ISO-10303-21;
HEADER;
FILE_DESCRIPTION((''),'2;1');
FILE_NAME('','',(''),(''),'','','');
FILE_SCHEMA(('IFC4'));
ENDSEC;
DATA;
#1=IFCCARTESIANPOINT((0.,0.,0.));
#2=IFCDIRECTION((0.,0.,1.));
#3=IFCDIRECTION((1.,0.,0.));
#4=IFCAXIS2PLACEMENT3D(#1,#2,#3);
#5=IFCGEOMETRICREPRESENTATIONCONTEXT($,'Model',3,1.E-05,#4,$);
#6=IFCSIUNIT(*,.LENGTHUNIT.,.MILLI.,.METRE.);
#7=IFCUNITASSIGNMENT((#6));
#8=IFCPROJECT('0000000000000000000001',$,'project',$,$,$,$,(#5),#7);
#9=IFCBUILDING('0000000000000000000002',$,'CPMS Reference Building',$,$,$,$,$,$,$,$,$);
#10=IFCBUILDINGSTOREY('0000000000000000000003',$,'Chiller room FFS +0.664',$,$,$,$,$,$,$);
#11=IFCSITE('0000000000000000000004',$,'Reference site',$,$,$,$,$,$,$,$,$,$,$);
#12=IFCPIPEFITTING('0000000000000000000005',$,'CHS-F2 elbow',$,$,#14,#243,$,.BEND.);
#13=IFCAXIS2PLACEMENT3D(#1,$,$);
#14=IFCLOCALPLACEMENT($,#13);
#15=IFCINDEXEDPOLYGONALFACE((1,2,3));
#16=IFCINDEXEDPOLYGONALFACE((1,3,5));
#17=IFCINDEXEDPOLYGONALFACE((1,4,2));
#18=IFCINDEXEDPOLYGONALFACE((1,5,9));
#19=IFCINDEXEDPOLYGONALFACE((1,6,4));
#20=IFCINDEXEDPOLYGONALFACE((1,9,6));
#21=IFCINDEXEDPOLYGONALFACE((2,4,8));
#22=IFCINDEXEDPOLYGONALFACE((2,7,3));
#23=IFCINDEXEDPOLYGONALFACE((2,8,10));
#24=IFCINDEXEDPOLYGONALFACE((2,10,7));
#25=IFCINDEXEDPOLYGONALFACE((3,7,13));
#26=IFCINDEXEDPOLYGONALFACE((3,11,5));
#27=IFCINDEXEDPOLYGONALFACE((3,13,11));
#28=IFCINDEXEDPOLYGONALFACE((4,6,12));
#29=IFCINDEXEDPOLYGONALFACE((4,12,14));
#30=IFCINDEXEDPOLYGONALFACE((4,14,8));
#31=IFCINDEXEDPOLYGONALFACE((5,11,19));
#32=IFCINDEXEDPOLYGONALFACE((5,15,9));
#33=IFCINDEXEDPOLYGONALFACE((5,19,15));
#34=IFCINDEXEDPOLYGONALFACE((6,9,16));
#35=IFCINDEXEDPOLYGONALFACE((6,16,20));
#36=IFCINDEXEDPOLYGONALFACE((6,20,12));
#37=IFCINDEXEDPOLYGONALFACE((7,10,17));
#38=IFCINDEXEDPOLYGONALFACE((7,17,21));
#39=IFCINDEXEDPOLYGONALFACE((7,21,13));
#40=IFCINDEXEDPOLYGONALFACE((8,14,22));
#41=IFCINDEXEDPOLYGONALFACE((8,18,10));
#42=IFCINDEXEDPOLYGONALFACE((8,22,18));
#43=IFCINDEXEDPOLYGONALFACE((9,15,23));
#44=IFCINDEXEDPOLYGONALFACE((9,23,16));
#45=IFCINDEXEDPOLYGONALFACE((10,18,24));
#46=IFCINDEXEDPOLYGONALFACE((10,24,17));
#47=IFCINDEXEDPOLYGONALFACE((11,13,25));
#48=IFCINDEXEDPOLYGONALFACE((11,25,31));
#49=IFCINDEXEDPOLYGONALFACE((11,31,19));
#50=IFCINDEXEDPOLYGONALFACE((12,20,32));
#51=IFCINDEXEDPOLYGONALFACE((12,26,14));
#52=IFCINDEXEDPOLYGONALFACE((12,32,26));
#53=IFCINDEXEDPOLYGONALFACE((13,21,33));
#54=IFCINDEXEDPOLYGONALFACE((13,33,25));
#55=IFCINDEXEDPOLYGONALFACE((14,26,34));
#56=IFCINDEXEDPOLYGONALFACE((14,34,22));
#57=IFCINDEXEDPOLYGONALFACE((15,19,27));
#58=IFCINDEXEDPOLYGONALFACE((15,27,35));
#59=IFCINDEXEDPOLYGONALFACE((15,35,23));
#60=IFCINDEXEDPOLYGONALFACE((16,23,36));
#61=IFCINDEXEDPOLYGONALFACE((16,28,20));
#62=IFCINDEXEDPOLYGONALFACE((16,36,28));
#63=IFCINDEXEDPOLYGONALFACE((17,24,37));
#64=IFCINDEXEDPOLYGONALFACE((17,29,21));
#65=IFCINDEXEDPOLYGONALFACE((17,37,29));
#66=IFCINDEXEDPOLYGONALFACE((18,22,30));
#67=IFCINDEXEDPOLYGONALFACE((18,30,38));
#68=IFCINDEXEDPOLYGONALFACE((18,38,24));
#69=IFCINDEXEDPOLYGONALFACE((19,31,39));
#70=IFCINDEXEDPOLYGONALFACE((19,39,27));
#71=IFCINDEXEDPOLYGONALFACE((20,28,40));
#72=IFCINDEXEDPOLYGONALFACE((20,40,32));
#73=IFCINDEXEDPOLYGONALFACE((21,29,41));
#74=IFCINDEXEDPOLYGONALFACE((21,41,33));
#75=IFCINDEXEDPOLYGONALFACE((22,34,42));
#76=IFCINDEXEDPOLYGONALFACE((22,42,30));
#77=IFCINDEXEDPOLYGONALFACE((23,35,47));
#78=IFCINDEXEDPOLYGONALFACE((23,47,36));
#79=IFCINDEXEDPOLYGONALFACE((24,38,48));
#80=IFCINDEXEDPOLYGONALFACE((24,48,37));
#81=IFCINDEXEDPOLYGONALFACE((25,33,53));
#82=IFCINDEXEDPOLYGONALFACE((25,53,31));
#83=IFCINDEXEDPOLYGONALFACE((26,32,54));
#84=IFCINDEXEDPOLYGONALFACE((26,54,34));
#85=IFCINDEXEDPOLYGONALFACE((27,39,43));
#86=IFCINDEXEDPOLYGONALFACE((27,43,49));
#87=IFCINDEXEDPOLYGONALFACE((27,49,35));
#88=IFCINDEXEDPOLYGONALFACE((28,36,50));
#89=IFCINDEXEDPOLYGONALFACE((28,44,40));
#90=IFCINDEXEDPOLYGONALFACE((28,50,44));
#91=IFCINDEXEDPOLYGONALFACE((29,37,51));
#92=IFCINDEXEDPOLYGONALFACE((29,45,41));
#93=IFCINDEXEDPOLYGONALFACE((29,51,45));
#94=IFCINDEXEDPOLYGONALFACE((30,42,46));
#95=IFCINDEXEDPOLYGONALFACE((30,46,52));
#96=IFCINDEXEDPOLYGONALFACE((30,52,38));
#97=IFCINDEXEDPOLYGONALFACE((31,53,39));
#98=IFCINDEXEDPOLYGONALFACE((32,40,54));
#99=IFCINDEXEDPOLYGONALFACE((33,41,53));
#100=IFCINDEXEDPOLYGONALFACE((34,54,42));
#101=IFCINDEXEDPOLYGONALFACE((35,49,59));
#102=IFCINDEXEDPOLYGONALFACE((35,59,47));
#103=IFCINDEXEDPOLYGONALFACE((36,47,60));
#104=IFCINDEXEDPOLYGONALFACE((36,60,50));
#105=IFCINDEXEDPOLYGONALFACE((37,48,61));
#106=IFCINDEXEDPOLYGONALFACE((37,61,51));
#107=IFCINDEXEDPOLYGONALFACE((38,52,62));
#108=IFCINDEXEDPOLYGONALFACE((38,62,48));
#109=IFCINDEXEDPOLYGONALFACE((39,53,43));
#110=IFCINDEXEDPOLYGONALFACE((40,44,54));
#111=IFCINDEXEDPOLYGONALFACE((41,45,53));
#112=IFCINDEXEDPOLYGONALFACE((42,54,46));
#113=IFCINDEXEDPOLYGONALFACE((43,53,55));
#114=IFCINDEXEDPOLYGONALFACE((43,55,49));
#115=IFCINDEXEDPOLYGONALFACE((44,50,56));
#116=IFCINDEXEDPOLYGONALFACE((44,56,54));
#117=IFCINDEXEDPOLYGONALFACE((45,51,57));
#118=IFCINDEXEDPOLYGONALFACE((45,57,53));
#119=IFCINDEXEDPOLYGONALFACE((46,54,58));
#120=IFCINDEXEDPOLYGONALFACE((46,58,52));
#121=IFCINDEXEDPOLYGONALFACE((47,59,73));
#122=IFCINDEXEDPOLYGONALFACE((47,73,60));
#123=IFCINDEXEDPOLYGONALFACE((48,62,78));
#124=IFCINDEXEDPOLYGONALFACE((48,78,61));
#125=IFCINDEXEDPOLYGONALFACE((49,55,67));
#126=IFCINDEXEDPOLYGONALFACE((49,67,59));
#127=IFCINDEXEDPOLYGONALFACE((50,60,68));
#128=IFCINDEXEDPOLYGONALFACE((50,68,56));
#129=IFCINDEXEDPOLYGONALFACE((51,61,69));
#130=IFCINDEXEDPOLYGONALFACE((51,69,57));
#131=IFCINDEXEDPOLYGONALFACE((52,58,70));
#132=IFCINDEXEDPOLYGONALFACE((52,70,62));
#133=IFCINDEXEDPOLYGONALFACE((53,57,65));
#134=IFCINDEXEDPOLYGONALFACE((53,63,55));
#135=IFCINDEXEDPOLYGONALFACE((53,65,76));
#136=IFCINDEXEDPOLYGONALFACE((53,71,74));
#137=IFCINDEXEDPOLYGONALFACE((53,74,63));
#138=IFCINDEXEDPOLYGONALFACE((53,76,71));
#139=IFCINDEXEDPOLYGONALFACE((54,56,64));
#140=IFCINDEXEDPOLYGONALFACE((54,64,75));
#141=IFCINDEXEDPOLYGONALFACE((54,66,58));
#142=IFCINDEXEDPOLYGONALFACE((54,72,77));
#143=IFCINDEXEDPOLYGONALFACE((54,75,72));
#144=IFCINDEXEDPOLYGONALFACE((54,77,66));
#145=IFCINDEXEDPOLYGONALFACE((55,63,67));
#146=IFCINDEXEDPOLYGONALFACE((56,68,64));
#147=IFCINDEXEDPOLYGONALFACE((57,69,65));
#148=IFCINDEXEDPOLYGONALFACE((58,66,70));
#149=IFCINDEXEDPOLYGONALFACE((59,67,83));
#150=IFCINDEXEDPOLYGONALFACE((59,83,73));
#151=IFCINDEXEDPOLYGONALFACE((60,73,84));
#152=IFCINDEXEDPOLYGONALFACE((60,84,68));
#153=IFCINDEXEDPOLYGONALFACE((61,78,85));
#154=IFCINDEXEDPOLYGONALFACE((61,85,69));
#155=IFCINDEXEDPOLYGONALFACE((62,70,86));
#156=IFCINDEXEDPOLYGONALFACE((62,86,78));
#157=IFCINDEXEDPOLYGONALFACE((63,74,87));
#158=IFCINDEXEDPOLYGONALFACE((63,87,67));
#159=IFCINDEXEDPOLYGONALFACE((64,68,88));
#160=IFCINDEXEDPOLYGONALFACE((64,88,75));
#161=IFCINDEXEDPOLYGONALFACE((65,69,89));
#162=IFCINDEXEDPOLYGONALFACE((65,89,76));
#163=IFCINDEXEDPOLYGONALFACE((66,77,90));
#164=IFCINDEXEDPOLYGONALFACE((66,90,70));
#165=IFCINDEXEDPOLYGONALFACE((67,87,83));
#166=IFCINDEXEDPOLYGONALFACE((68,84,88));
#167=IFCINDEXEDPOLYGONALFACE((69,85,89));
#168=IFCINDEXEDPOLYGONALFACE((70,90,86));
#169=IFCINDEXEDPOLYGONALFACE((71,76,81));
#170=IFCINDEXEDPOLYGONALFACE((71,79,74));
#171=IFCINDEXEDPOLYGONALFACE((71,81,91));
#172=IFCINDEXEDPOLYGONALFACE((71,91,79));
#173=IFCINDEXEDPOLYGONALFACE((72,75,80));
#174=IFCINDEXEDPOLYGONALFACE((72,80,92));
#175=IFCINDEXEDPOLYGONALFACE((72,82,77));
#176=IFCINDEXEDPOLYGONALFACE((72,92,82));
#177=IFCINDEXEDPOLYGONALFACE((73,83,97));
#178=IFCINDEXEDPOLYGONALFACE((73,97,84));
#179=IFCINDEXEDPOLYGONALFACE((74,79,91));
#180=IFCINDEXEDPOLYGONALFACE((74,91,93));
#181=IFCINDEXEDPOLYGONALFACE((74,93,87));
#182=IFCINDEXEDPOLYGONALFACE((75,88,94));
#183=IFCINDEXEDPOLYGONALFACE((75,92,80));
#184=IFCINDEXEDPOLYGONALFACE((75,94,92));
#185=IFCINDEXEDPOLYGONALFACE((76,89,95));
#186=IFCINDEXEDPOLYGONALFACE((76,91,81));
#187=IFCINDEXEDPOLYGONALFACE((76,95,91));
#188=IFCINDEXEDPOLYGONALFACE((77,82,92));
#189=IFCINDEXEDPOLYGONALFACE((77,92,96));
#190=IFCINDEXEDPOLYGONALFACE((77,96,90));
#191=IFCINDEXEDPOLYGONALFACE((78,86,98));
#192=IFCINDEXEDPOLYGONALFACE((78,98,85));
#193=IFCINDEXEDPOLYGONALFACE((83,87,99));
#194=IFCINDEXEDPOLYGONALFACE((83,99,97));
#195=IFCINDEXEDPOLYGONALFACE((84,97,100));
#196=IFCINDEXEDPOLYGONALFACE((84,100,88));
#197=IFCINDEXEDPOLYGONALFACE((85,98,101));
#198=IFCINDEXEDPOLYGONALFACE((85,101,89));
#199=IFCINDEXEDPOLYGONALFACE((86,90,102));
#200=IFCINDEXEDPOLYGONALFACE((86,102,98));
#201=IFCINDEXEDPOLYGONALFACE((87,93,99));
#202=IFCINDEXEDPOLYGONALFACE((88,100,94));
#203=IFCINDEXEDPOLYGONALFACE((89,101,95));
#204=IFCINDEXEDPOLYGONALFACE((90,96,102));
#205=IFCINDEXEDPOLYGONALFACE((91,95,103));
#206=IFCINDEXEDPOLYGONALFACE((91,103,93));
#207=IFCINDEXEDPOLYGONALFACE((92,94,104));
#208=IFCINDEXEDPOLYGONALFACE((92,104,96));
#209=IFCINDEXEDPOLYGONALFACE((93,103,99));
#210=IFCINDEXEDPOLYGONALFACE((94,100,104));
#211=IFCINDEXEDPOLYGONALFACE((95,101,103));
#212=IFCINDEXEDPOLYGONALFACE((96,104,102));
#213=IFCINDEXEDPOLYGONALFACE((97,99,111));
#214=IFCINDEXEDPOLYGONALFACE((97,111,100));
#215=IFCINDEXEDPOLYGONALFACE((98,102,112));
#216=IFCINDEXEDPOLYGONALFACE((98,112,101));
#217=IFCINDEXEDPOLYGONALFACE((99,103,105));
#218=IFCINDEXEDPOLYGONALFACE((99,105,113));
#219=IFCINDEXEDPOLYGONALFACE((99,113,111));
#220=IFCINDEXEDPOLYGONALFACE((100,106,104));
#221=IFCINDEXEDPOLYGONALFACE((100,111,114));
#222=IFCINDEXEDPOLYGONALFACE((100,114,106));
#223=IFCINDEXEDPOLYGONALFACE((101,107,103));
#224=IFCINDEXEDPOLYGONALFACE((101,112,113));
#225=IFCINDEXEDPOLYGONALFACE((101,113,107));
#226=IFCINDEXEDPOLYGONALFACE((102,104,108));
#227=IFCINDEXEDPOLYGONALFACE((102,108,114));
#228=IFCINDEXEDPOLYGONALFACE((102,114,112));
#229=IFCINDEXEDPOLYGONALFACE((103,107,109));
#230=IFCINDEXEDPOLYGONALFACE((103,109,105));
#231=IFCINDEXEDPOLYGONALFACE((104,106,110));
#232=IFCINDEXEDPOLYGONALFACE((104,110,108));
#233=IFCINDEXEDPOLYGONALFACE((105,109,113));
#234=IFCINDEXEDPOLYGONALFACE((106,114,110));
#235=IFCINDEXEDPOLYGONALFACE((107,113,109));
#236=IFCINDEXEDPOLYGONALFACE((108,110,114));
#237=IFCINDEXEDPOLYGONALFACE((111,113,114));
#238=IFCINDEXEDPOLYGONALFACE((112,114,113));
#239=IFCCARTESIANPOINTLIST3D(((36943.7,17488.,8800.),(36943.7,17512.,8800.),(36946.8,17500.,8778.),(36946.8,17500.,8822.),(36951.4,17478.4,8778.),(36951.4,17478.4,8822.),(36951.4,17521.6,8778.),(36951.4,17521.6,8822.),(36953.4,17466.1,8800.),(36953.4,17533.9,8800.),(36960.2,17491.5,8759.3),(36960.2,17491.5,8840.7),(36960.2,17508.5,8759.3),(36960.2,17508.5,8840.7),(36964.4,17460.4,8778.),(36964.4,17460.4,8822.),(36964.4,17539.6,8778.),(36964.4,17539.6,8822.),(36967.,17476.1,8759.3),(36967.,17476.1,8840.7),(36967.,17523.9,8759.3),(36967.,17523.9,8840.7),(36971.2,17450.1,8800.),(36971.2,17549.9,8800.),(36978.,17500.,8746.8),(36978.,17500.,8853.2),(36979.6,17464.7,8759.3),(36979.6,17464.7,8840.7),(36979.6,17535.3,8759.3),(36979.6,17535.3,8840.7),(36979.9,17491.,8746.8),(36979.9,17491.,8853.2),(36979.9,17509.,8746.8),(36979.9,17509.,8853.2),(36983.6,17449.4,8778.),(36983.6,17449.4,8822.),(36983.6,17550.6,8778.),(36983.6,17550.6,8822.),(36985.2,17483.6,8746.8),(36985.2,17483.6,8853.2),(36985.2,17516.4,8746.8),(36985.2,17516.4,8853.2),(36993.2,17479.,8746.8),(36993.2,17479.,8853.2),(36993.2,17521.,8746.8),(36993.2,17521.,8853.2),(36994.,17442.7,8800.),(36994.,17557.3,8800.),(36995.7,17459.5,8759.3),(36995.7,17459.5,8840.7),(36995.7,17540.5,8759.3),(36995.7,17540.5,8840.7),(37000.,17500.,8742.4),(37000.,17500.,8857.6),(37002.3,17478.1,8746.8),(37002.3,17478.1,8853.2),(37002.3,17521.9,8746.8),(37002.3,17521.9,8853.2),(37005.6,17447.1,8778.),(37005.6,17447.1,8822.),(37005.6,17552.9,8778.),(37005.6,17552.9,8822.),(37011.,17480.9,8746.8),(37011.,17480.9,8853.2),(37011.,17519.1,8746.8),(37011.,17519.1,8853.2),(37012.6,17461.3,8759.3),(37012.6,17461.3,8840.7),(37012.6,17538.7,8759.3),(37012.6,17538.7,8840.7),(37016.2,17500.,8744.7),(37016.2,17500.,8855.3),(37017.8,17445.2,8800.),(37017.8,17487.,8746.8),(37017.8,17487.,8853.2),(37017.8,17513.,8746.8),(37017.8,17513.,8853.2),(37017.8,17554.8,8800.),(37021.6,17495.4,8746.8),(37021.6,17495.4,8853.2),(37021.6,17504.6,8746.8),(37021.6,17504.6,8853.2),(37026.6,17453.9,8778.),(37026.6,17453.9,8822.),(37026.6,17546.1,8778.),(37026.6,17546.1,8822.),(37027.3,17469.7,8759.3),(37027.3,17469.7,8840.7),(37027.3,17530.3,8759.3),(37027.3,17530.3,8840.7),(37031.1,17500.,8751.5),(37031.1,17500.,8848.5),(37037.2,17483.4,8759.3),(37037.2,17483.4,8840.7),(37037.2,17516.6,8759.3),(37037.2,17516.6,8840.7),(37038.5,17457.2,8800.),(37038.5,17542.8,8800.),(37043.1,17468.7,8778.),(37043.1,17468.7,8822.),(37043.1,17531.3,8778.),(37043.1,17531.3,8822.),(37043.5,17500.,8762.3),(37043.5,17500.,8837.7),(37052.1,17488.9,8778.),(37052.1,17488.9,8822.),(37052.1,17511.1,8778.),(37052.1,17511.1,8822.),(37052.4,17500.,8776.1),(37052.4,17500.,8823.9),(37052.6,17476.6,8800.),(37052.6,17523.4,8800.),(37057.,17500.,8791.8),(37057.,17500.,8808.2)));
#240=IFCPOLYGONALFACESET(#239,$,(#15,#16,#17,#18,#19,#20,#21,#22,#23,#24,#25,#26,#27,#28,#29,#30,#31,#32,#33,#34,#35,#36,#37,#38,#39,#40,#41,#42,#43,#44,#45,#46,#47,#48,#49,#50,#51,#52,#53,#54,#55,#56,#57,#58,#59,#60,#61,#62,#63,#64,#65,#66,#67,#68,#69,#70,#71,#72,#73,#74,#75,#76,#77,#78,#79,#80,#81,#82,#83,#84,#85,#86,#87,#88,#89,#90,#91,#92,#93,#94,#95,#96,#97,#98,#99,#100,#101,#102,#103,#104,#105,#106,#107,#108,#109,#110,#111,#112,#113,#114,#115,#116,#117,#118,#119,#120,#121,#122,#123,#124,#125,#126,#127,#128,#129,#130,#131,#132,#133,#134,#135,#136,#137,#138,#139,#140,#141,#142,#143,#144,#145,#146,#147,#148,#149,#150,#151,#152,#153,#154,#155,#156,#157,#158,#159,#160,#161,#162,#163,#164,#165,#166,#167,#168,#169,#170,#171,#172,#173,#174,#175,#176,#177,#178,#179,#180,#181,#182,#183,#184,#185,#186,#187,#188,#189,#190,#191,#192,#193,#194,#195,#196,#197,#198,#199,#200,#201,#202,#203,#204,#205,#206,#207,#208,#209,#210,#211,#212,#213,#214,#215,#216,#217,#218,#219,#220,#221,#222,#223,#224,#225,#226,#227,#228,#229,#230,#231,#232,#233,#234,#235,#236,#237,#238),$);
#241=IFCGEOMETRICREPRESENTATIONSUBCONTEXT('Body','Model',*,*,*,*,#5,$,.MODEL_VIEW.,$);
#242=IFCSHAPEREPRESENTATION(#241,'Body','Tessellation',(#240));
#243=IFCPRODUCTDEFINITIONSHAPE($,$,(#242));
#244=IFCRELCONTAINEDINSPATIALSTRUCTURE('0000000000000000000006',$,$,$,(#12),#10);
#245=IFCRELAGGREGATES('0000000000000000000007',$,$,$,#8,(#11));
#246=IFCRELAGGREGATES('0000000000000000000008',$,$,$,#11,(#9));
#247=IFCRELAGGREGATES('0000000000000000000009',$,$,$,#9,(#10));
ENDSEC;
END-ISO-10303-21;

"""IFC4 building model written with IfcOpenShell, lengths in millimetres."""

from ifc_helpers import new_model, entity, si_unit, origin_with_axes, place, context, subcontext, project, spatial, element, save


model = new_model("IFC4")

# Units and contexts
model_context = context("Model", 3, precision=1e-05, world=origin_with_axes())
body_context = subcontext(model_context, "Body", "Model", "MODEL_VIEW")
ifc_project = project(units=[si_unit("LENGTHUNIT", "METRE", prefix="MILLI")], contexts=[model_context])

# Site, building, storey
site = spatial("IfcSite", under=ifc_project, Name="Reference site")
building = spatial("IfcBuilding", under=site, Name="CPMS Reference Building")
storey = spatial("IfcBuildingStorey", under=building, Name="Chiller room FFS +0.664")

# Pipe fitting
pipe_fitting_1_placement = place(None, origin_with_axes())
element("IfcPipeFitting", 1, at=pipe_fitting_1_placement, inside=storey, Name="CHS-F2 elbow", PredefinedType="BEND", context=body_context, shape_type="CSG", body=[
    entity("IfcSphere", entity("IfcAxis2Placement3D", entity("IfcCartesianPoint", [37000.0, 17500.0, 8800.0]), entity("IfcDirection", [0.0, 0.0, 1.0]), entity("IfcDirection", [1.0, 0.0, 0.0])), 57.6),
])

save(model, "model.ifc")
